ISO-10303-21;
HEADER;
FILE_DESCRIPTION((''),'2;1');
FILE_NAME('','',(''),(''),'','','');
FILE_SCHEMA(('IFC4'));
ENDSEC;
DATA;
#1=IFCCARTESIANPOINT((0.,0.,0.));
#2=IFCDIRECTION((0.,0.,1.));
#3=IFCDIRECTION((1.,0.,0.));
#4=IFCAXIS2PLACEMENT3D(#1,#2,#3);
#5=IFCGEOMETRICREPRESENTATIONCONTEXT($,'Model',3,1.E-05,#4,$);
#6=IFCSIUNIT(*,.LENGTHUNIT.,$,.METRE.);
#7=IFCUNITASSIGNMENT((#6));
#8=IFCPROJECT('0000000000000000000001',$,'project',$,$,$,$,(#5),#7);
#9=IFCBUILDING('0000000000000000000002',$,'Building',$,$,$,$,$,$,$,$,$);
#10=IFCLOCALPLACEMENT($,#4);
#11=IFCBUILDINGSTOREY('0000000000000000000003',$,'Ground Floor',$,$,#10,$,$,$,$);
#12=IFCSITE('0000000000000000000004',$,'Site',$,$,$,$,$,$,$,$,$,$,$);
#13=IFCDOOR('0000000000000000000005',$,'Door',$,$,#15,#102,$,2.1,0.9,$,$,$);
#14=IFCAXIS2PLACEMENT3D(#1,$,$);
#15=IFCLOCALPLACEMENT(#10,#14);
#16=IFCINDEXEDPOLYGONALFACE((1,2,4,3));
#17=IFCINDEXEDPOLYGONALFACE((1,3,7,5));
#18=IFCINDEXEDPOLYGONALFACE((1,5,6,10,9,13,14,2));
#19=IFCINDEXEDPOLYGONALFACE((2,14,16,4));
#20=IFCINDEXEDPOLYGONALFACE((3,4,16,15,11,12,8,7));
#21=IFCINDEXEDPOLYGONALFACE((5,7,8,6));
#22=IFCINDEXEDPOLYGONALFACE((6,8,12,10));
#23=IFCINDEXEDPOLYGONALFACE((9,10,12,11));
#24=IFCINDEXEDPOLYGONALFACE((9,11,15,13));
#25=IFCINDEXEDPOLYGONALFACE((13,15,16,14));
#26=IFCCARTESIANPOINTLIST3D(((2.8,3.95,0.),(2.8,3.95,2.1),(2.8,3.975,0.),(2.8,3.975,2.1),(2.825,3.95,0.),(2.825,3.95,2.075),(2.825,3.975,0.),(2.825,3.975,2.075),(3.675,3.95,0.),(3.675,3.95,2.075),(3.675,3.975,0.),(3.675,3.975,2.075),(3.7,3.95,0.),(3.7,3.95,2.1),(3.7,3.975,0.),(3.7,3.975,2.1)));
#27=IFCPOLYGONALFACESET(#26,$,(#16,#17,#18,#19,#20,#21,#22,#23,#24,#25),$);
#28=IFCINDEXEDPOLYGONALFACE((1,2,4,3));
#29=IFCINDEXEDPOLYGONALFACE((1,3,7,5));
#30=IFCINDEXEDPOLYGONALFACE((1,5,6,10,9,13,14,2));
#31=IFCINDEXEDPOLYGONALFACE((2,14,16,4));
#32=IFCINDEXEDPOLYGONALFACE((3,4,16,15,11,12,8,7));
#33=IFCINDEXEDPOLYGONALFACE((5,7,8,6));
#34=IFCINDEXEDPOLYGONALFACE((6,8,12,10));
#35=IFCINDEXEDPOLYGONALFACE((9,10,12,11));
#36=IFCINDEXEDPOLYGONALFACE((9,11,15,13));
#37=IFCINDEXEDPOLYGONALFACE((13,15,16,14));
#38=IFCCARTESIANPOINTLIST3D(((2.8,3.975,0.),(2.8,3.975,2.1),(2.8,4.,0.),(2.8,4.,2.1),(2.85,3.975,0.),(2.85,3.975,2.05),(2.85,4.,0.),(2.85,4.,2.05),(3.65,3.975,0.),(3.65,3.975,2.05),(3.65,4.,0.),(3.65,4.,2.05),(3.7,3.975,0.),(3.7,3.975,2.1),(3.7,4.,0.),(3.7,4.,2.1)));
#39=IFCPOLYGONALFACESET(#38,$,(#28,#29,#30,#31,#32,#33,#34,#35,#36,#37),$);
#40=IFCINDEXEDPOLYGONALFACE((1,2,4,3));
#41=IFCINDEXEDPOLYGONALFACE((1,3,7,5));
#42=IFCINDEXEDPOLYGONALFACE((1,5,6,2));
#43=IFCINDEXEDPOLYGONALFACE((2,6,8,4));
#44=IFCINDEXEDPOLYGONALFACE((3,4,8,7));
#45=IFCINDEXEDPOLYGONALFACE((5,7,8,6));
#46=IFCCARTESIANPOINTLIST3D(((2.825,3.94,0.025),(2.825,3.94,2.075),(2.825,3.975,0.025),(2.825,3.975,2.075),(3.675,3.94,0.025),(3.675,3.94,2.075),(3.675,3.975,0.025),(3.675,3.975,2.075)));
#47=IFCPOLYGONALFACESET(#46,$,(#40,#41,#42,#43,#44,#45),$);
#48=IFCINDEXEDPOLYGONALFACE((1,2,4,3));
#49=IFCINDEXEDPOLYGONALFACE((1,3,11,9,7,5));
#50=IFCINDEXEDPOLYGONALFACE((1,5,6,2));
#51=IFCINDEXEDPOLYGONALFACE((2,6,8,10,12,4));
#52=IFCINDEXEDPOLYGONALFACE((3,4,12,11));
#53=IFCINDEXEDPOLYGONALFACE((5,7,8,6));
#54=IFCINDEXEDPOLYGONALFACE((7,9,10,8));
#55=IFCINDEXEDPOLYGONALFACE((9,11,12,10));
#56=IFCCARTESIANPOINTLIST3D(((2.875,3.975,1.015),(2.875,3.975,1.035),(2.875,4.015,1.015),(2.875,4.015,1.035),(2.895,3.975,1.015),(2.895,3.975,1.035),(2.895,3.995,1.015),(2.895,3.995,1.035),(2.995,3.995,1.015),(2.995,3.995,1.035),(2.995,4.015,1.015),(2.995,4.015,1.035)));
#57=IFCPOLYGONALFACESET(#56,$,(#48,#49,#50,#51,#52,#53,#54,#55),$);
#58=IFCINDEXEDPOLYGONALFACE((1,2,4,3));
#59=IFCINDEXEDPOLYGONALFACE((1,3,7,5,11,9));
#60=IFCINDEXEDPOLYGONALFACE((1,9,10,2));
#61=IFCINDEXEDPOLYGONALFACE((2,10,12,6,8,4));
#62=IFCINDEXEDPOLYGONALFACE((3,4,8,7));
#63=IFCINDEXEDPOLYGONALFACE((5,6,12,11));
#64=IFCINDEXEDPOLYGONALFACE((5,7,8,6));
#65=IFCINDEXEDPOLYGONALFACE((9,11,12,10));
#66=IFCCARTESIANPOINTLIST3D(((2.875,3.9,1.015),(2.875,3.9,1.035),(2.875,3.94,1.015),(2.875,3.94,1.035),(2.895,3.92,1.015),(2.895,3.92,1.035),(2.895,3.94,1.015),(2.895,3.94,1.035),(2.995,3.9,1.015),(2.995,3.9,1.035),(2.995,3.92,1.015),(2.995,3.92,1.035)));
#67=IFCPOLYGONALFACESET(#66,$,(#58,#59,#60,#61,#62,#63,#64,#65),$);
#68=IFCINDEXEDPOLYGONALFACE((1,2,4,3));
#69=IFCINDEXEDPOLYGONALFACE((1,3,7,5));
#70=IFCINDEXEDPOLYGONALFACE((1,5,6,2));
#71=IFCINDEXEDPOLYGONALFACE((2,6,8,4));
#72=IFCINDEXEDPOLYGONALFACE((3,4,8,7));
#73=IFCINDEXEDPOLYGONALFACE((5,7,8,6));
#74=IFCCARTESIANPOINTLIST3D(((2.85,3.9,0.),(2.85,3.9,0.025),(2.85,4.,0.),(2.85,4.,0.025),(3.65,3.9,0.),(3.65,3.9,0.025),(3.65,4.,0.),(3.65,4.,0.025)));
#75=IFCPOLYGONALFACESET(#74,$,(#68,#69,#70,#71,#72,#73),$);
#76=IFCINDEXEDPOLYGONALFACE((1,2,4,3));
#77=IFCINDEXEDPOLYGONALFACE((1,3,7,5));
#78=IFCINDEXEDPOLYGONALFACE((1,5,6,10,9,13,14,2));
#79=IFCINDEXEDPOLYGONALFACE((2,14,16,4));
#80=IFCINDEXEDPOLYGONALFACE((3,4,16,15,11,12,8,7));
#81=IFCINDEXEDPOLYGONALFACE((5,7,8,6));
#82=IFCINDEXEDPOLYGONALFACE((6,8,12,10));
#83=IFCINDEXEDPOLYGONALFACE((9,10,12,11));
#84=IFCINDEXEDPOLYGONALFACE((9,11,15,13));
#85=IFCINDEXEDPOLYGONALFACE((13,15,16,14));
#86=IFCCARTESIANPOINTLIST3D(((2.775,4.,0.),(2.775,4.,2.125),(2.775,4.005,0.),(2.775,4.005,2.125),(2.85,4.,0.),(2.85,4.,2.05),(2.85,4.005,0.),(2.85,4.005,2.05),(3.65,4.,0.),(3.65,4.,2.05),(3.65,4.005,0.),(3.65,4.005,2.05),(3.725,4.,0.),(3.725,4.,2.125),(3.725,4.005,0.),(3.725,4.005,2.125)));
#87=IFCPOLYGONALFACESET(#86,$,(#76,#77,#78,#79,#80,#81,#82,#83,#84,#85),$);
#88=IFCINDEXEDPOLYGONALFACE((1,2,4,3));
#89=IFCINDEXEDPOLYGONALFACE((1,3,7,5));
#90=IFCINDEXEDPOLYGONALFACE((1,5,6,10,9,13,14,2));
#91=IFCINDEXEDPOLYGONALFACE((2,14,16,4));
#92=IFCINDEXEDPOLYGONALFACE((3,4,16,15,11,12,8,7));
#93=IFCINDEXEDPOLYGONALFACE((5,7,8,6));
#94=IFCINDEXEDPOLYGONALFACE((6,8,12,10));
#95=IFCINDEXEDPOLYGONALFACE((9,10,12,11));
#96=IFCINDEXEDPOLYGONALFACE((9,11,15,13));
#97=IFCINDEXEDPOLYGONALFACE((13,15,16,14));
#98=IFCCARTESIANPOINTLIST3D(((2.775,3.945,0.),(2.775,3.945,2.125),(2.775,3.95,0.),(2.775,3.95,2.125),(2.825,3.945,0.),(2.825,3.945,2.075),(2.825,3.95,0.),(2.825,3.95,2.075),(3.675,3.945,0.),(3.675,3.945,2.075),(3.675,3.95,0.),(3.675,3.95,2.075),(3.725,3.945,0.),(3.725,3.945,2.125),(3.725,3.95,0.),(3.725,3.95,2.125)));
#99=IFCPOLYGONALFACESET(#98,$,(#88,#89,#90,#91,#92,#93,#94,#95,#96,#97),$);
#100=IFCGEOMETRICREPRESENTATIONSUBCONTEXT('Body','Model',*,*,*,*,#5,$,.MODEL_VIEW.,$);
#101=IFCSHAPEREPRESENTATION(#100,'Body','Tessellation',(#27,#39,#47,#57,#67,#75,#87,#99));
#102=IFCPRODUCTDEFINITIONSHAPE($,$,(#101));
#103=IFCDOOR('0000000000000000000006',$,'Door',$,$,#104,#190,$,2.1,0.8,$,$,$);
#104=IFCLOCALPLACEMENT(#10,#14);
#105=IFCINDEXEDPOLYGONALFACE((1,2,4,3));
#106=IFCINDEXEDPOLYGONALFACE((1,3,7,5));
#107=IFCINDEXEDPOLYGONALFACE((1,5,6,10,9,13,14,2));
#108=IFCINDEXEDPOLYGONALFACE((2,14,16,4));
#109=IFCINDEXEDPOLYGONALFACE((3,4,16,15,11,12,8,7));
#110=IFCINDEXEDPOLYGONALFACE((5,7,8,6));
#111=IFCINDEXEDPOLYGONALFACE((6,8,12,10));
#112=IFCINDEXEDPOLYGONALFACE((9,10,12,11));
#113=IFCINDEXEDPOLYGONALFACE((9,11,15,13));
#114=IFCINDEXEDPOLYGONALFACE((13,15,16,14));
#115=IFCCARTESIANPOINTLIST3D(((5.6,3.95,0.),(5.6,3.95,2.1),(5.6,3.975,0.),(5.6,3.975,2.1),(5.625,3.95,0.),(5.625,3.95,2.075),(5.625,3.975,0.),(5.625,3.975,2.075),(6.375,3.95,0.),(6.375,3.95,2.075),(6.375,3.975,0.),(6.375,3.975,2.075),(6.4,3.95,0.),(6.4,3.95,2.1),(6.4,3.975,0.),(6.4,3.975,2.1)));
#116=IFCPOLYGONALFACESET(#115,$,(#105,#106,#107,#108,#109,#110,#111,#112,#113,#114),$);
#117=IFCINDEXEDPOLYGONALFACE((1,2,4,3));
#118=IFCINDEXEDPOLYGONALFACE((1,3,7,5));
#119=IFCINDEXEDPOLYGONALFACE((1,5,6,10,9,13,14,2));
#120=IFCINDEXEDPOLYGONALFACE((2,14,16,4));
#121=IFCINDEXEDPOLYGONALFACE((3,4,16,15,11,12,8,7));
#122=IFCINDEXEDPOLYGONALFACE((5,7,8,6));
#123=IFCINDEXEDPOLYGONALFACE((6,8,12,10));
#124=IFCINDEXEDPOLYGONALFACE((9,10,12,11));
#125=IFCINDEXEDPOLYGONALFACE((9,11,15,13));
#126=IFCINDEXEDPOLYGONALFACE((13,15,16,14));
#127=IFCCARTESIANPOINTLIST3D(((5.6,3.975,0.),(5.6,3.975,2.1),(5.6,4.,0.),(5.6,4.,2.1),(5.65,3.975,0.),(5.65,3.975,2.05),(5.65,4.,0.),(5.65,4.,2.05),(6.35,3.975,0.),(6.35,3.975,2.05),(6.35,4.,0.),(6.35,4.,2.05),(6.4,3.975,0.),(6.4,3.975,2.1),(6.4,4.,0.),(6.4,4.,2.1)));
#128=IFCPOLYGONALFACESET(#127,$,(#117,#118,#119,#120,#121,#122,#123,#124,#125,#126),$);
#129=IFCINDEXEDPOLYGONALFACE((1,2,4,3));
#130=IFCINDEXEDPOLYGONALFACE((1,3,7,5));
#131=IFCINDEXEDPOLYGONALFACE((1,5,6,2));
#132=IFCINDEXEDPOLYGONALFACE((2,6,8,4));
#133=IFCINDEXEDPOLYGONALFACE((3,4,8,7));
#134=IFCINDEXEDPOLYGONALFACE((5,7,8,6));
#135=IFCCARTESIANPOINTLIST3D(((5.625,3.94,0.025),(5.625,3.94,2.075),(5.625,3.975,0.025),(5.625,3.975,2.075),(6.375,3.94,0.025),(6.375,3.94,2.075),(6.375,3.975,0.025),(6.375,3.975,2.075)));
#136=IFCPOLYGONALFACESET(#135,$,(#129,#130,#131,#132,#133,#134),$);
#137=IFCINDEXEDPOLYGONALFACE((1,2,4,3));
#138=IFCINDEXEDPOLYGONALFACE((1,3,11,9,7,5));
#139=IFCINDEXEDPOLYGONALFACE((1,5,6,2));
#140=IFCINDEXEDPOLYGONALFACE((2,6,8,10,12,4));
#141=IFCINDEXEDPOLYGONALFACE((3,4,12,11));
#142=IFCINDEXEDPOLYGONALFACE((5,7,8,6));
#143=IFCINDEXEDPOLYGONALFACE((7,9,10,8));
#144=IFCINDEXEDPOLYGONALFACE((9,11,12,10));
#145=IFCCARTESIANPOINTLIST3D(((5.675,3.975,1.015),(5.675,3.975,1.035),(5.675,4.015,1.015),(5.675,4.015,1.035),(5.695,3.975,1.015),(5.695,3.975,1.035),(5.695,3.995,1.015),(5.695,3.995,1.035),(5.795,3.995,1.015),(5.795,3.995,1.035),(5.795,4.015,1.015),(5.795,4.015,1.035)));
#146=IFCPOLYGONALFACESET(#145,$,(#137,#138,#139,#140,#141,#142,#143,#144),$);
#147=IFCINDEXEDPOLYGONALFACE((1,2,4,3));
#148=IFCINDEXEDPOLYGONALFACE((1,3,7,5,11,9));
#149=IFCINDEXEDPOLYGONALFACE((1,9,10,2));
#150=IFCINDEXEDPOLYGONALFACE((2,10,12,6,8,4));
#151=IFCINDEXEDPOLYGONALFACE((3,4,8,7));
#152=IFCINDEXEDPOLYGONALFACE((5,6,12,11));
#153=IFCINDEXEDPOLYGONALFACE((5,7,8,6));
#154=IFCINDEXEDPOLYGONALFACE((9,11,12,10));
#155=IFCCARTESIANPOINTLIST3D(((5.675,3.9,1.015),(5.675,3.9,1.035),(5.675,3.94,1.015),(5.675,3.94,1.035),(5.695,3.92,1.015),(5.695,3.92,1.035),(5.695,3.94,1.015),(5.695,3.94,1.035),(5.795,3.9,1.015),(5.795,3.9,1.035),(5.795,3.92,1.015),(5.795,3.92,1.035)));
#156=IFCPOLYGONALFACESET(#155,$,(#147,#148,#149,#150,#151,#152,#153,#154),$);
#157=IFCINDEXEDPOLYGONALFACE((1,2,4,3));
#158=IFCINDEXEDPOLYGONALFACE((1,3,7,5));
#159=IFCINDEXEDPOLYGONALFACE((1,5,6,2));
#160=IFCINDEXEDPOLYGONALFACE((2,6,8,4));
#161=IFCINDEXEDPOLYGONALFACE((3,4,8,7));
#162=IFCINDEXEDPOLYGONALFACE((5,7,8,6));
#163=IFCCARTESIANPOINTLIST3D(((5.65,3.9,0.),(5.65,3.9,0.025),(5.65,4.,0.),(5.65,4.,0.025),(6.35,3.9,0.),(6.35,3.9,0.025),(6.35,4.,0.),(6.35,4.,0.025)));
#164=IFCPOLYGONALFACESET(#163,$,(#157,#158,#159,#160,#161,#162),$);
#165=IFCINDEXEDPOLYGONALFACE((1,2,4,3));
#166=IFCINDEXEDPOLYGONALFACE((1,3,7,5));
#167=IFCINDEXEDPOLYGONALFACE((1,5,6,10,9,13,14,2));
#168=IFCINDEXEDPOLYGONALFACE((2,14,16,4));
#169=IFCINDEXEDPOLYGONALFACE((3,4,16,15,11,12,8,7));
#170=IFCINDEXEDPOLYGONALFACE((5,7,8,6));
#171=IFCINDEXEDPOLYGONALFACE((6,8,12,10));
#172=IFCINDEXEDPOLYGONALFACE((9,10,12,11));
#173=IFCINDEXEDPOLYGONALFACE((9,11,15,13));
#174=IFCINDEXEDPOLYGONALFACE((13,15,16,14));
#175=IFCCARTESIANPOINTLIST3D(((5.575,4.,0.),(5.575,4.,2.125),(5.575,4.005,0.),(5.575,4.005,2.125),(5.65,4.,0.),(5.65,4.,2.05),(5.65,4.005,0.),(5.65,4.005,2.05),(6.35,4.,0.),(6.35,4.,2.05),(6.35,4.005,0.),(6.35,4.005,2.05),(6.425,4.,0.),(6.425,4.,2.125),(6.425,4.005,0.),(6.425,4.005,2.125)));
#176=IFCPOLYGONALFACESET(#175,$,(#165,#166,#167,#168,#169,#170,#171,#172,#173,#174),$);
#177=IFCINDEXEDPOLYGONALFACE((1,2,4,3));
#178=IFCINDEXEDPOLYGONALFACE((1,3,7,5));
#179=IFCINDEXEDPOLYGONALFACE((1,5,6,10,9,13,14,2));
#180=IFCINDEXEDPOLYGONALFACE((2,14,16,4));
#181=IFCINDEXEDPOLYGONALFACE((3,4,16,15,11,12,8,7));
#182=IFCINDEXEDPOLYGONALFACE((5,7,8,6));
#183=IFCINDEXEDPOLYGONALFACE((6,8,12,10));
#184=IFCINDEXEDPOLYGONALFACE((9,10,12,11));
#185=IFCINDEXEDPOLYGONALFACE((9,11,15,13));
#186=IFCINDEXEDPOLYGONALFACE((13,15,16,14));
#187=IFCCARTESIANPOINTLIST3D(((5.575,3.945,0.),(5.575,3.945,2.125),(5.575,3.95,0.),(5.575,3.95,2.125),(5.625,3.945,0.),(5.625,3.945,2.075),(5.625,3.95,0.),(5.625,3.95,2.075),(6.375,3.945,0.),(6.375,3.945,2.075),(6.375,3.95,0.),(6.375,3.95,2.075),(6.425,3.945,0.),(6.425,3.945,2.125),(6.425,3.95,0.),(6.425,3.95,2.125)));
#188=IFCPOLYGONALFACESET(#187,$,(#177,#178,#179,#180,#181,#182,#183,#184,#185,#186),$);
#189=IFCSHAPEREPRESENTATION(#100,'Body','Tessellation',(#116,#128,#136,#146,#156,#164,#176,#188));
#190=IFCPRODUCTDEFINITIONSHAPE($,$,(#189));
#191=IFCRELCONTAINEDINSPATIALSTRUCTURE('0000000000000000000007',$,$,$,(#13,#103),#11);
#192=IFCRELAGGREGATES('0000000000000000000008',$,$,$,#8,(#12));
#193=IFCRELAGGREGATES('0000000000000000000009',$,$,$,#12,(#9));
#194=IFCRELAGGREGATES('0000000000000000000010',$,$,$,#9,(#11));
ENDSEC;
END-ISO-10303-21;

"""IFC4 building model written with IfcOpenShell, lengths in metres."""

from ifc_helpers import new_model, si_unit, frame, origin_with_axes, place, context, subcontext, project, spatial, line, indexed_curve, outline, extrude, element, save


model = new_model("IFC4")

# Units and contexts
model_context = context("Model", 3, precision=1e-05, world=origin_with_axes())
body_context = subcontext(model_context, "Body", "Model", "MODEL_VIEW")
ifc_project = project(units=[si_unit("LENGTHUNIT", "METRE")], contexts=[model_context])

# Site, building, storey
site = spatial("IfcSite", under=ifc_project, Name="Site")
building = spatial("IfcBuilding", under=site, Name="Building")
storey_placement = place(None, origin_with_axes())
storey = spatial("IfcBuildingStorey", under=building, at=storey_placement, Name="Ground Floor")

# Doors
door_1_placement = place(storey_placement, frame((3.7, 4.0, 0.0), z_axis=(0.0, 0.0, 1.0), x_axis=(-1.0, 0.0, 0.0)))
element("IfcDoor", 1, at=door_1_placement, inside=storey, Name="Door", OverallHeight=2.1, OverallWidth=0.9, context=body_context, shape_type="SweptSolid", body=[
    extrude(outline(indexed_curve([(0.0, 0.0), (0.0, 2.1), (0.9, 2.1), (0.9, 0.0), (0.875, 0.0), (0.875, 2.075), (0.025, 2.075), (0.025, 0.0)], segments=[line(1, 2, 3, 4, 5, 6, 7, 8, 1)])), frame((0.0, 0.025, 0.0), z_axis=(0.0, -1.0, 0.0), x_axis=(1.0, 0.0, 0.0)), (0.0, 0.0, -1.0), 0.025),
    extrude(outline(indexed_curve([(0.0, 0.0), (0.0, 2.1), (0.9, 2.1), (0.9, 0.0), (0.85, 0.0), (0.85, 2.05), (0.05, 2.05), (0.05, 0.0)], segments=[line(1, 2, 3, 4, 5, 6, 7, 8, 1)])), frame((0.0, 0.0, 0.0), z_axis=(0.0, -1.0, 0.0), x_axis=(1.0, 0.0, 0.0)), (0.0, 0.0, -1.0), 0.025),
    extrude(outline(indexed_curve([(0.0, 0.0), (0.85, 0.0), (0.85, 0.035), (0.0, 0.035)], segments=[line(1, 2, 3, 4, 1)])), frame((0.025, 0.025, 0.025), z_axis=(0.0, 0.0, 1.0), x_axis=(1.0, 0.0, 0.0)), (0.0, 0.0, 1.0), 2.05),
    extrude(outline(indexed_curve([(0.0, 0.0), (0.0, -0.04), (-0.12, -0.04), (-0.12, -0.02), (-0.02, -0.02), (-0.02, 0.0)], segments=[line(1, 2, 3, 4, 5, 6, 1)])), frame((0.825, 0.025, 1.015), z_axis=(0.0, 0.0, 1.0), x_axis=(1.0, 0.0, 0.0)), (0.0, 0.0, 1.0), 0.02),
    extrude(outline(indexed_curve([(0.0, 0.0), (0.0, 0.04), (-0.12, 0.04), (-0.12, 0.02), (-0.02, 0.02), (-0.02, 0.0)], segments=[line(1, 2, 3, 4, 5, 6, 1)])), frame((0.825, 0.06, 1.015), z_axis=(0.0, 0.0, 1.0), x_axis=(1.0, 0.0, 0.0)), (0.0, 0.0, 1.0), 0.02),
    extrude(outline(indexed_curve([(0.0, 0.0), (0.8, 0.0), (0.8, 0.1), (0.0, 0.1)], segments=[line(1, 2, 3, 4, 1)])), frame((0.05, 0.0, 0.0), z_axis=(0.0, 0.0, 1.0), x_axis=(1.0, 0.0, 0.0)), (0.0, 0.0, 1.0), 0.025),
    extrude(outline(indexed_curve([(0.0, 0.0), (0.0, 2.125), (0.95, 2.125), (0.95, 0.0), (0.875, 0.0), (0.875, 2.05), (0.075, 2.05), (0.075, 0.0)], segments=[line(1, 2, 3, 4, 5, 6, 7, 8, 1)])), frame((-0.025, -0.005, 0.0), z_axis=(0.0, -1.0, 0.0), x_axis=(1.0, 0.0, 0.0)), (0.0, 0.0, -1.0), 0.005),
    extrude(outline(indexed_curve([(0.0, 0.0), (0.0, 2.125), (0.95, 2.125), (0.95, 0.0), (0.9, 0.0), (0.9, 2.075), (0.05, 2.075), (0.05, 0.0)], segments=[line(1, 2, 3, 4, 5, 6, 7, 8, 1)])), frame((-0.025, 0.05, 0.0), z_axis=(0.0, -1.0, 0.0), x_axis=(1.0, 0.0, 0.0)), (0.0, 0.0, -1.0), 0.005),
])
door_2_placement = place(storey_placement, frame((6.4, 4.0, 0.0), z_axis=(0.0, 0.0, 1.0), x_axis=(-1.0, 0.0, 0.0)))
element("IfcDoor", 2, at=door_2_placement, inside=storey, Name="Door", OverallHeight=2.1, OverallWidth=0.8, context=body_context, shape_type="SweptSolid", body=[
    extrude(outline(indexed_curve([(0.0, 0.0), (0.0, 2.1), (0.8, 2.1), (0.8, 0.0), (0.775, 0.0), (0.775, 2.075), (0.025, 2.075), (0.025, 0.0)], segments=[line(1, 2, 3, 4, 5, 6, 7, 8, 1)])), frame((0.0, 0.025, 0.0), z_axis=(0.0, -1.0, 0.0), x_axis=(1.0, 0.0, 0.0)), (0.0, 0.0, -1.0), 0.025),
    extrude(outline(indexed_curve([(0.0, 0.0), (0.0, 2.1), (0.8, 2.1), (0.8, 0.0), (0.75, 0.0), (0.75, 2.05), (0.05, 2.05), (0.05, 0.0)], segments=[line(1, 2, 3, 4, 5, 6, 7, 8, 1)])), frame((0.0, 0.0, 0.0), z_axis=(0.0, -1.0, 0.0), x_axis=(1.0, 0.0, 0.0)), (0.0, 0.0, -1.0), 0.025),
    extrude(outline(indexed_curve([(0.0, 0.0), (0.75, 0.0), (0.75, 0.035), (0.0, 0.035)], segments=[line(1, 2, 3, 4, 1)])), frame((0.025, 0.025, 0.025), z_axis=(0.0, 0.0, 1.0), x_axis=(1.0, 0.0, 0.0)), (0.0, 0.0, 1.0), 2.05),
    extrude(outline(indexed_curve([(0.0, 0.0), (0.0, -0.04), (-0.12, -0.04), (-0.12, -0.02), (-0.02, -0.02), (-0.02, 0.0)], segments=[line(1, 2, 3, 4, 5, 6, 1)])), frame((0.725, 0.025, 1.015), z_axis=(0.0, 0.0, 1.0), x_axis=(1.0, 0.0, 0.0)), (0.0, 0.0, 1.0), 0.02),
    extrude(outline(indexed_curve([(0.0, 0.0), (0.0, 0.04), (-0.12, 0.04), (-0.12, 0.02), (-0.02, 0.02), (-0.02, 0.0)], segments=[line(1, 2, 3, 4, 5, 6, 1)])), frame((0.725, 0.06, 1.015), z_axis=(0.0, 0.0, 1.0), x_axis=(1.0, 0.0, 0.0)), (0.0, 0.0, 1.0), 0.02),
    extrude(outline(indexed_curve([(0.0, 0.0), (0.7, 0.0), (0.7, 0.1), (0.0, 0.1)], segments=[line(1, 2, 3, 4, 1)])), frame((0.05, 0.0, 0.0), z_axis=(0.0, 0.0, 1.0), x_axis=(1.0, 0.0, 0.0)), (0.0, 0.0, 1.0), 0.025),
    extrude(outline(indexed_curve([(0.0, 0.0), (0.0, 2.125), (0.85, 2.125), (0.85, 0.0), (0.775, 0.0), (0.775, 2.05), (0.075, 2.05), (0.075, 0.0)], segments=[line(1, 2, 3, 4, 5, 6, 7, 8, 1)])), frame((-0.025, -0.005, 0.0), z_axis=(0.0, -1.0, 0.0), x_axis=(1.0, 0.0, 0.0)), (0.0, 0.0, -1.0), 0.005),
    extrude(outline(indexed_curve([(0.0, 0.0), (0.0, 2.125), (0.85, 2.125), (0.85, 0.0), (0.8, 0.0), (0.8, 2.075), (0.05, 2.075), (0.05, 0.0)], segments=[line(1, 2, 3, 4, 5, 6, 7, 8, 1)])), frame((-0.025, 0.05, 0.0), z_axis=(0.0, -1.0, 0.0), x_axis=(1.0, 0.0, 0.0)), (0.0, 0.0, -1.0), 0.005),
])

save(model, "model.ifc")
